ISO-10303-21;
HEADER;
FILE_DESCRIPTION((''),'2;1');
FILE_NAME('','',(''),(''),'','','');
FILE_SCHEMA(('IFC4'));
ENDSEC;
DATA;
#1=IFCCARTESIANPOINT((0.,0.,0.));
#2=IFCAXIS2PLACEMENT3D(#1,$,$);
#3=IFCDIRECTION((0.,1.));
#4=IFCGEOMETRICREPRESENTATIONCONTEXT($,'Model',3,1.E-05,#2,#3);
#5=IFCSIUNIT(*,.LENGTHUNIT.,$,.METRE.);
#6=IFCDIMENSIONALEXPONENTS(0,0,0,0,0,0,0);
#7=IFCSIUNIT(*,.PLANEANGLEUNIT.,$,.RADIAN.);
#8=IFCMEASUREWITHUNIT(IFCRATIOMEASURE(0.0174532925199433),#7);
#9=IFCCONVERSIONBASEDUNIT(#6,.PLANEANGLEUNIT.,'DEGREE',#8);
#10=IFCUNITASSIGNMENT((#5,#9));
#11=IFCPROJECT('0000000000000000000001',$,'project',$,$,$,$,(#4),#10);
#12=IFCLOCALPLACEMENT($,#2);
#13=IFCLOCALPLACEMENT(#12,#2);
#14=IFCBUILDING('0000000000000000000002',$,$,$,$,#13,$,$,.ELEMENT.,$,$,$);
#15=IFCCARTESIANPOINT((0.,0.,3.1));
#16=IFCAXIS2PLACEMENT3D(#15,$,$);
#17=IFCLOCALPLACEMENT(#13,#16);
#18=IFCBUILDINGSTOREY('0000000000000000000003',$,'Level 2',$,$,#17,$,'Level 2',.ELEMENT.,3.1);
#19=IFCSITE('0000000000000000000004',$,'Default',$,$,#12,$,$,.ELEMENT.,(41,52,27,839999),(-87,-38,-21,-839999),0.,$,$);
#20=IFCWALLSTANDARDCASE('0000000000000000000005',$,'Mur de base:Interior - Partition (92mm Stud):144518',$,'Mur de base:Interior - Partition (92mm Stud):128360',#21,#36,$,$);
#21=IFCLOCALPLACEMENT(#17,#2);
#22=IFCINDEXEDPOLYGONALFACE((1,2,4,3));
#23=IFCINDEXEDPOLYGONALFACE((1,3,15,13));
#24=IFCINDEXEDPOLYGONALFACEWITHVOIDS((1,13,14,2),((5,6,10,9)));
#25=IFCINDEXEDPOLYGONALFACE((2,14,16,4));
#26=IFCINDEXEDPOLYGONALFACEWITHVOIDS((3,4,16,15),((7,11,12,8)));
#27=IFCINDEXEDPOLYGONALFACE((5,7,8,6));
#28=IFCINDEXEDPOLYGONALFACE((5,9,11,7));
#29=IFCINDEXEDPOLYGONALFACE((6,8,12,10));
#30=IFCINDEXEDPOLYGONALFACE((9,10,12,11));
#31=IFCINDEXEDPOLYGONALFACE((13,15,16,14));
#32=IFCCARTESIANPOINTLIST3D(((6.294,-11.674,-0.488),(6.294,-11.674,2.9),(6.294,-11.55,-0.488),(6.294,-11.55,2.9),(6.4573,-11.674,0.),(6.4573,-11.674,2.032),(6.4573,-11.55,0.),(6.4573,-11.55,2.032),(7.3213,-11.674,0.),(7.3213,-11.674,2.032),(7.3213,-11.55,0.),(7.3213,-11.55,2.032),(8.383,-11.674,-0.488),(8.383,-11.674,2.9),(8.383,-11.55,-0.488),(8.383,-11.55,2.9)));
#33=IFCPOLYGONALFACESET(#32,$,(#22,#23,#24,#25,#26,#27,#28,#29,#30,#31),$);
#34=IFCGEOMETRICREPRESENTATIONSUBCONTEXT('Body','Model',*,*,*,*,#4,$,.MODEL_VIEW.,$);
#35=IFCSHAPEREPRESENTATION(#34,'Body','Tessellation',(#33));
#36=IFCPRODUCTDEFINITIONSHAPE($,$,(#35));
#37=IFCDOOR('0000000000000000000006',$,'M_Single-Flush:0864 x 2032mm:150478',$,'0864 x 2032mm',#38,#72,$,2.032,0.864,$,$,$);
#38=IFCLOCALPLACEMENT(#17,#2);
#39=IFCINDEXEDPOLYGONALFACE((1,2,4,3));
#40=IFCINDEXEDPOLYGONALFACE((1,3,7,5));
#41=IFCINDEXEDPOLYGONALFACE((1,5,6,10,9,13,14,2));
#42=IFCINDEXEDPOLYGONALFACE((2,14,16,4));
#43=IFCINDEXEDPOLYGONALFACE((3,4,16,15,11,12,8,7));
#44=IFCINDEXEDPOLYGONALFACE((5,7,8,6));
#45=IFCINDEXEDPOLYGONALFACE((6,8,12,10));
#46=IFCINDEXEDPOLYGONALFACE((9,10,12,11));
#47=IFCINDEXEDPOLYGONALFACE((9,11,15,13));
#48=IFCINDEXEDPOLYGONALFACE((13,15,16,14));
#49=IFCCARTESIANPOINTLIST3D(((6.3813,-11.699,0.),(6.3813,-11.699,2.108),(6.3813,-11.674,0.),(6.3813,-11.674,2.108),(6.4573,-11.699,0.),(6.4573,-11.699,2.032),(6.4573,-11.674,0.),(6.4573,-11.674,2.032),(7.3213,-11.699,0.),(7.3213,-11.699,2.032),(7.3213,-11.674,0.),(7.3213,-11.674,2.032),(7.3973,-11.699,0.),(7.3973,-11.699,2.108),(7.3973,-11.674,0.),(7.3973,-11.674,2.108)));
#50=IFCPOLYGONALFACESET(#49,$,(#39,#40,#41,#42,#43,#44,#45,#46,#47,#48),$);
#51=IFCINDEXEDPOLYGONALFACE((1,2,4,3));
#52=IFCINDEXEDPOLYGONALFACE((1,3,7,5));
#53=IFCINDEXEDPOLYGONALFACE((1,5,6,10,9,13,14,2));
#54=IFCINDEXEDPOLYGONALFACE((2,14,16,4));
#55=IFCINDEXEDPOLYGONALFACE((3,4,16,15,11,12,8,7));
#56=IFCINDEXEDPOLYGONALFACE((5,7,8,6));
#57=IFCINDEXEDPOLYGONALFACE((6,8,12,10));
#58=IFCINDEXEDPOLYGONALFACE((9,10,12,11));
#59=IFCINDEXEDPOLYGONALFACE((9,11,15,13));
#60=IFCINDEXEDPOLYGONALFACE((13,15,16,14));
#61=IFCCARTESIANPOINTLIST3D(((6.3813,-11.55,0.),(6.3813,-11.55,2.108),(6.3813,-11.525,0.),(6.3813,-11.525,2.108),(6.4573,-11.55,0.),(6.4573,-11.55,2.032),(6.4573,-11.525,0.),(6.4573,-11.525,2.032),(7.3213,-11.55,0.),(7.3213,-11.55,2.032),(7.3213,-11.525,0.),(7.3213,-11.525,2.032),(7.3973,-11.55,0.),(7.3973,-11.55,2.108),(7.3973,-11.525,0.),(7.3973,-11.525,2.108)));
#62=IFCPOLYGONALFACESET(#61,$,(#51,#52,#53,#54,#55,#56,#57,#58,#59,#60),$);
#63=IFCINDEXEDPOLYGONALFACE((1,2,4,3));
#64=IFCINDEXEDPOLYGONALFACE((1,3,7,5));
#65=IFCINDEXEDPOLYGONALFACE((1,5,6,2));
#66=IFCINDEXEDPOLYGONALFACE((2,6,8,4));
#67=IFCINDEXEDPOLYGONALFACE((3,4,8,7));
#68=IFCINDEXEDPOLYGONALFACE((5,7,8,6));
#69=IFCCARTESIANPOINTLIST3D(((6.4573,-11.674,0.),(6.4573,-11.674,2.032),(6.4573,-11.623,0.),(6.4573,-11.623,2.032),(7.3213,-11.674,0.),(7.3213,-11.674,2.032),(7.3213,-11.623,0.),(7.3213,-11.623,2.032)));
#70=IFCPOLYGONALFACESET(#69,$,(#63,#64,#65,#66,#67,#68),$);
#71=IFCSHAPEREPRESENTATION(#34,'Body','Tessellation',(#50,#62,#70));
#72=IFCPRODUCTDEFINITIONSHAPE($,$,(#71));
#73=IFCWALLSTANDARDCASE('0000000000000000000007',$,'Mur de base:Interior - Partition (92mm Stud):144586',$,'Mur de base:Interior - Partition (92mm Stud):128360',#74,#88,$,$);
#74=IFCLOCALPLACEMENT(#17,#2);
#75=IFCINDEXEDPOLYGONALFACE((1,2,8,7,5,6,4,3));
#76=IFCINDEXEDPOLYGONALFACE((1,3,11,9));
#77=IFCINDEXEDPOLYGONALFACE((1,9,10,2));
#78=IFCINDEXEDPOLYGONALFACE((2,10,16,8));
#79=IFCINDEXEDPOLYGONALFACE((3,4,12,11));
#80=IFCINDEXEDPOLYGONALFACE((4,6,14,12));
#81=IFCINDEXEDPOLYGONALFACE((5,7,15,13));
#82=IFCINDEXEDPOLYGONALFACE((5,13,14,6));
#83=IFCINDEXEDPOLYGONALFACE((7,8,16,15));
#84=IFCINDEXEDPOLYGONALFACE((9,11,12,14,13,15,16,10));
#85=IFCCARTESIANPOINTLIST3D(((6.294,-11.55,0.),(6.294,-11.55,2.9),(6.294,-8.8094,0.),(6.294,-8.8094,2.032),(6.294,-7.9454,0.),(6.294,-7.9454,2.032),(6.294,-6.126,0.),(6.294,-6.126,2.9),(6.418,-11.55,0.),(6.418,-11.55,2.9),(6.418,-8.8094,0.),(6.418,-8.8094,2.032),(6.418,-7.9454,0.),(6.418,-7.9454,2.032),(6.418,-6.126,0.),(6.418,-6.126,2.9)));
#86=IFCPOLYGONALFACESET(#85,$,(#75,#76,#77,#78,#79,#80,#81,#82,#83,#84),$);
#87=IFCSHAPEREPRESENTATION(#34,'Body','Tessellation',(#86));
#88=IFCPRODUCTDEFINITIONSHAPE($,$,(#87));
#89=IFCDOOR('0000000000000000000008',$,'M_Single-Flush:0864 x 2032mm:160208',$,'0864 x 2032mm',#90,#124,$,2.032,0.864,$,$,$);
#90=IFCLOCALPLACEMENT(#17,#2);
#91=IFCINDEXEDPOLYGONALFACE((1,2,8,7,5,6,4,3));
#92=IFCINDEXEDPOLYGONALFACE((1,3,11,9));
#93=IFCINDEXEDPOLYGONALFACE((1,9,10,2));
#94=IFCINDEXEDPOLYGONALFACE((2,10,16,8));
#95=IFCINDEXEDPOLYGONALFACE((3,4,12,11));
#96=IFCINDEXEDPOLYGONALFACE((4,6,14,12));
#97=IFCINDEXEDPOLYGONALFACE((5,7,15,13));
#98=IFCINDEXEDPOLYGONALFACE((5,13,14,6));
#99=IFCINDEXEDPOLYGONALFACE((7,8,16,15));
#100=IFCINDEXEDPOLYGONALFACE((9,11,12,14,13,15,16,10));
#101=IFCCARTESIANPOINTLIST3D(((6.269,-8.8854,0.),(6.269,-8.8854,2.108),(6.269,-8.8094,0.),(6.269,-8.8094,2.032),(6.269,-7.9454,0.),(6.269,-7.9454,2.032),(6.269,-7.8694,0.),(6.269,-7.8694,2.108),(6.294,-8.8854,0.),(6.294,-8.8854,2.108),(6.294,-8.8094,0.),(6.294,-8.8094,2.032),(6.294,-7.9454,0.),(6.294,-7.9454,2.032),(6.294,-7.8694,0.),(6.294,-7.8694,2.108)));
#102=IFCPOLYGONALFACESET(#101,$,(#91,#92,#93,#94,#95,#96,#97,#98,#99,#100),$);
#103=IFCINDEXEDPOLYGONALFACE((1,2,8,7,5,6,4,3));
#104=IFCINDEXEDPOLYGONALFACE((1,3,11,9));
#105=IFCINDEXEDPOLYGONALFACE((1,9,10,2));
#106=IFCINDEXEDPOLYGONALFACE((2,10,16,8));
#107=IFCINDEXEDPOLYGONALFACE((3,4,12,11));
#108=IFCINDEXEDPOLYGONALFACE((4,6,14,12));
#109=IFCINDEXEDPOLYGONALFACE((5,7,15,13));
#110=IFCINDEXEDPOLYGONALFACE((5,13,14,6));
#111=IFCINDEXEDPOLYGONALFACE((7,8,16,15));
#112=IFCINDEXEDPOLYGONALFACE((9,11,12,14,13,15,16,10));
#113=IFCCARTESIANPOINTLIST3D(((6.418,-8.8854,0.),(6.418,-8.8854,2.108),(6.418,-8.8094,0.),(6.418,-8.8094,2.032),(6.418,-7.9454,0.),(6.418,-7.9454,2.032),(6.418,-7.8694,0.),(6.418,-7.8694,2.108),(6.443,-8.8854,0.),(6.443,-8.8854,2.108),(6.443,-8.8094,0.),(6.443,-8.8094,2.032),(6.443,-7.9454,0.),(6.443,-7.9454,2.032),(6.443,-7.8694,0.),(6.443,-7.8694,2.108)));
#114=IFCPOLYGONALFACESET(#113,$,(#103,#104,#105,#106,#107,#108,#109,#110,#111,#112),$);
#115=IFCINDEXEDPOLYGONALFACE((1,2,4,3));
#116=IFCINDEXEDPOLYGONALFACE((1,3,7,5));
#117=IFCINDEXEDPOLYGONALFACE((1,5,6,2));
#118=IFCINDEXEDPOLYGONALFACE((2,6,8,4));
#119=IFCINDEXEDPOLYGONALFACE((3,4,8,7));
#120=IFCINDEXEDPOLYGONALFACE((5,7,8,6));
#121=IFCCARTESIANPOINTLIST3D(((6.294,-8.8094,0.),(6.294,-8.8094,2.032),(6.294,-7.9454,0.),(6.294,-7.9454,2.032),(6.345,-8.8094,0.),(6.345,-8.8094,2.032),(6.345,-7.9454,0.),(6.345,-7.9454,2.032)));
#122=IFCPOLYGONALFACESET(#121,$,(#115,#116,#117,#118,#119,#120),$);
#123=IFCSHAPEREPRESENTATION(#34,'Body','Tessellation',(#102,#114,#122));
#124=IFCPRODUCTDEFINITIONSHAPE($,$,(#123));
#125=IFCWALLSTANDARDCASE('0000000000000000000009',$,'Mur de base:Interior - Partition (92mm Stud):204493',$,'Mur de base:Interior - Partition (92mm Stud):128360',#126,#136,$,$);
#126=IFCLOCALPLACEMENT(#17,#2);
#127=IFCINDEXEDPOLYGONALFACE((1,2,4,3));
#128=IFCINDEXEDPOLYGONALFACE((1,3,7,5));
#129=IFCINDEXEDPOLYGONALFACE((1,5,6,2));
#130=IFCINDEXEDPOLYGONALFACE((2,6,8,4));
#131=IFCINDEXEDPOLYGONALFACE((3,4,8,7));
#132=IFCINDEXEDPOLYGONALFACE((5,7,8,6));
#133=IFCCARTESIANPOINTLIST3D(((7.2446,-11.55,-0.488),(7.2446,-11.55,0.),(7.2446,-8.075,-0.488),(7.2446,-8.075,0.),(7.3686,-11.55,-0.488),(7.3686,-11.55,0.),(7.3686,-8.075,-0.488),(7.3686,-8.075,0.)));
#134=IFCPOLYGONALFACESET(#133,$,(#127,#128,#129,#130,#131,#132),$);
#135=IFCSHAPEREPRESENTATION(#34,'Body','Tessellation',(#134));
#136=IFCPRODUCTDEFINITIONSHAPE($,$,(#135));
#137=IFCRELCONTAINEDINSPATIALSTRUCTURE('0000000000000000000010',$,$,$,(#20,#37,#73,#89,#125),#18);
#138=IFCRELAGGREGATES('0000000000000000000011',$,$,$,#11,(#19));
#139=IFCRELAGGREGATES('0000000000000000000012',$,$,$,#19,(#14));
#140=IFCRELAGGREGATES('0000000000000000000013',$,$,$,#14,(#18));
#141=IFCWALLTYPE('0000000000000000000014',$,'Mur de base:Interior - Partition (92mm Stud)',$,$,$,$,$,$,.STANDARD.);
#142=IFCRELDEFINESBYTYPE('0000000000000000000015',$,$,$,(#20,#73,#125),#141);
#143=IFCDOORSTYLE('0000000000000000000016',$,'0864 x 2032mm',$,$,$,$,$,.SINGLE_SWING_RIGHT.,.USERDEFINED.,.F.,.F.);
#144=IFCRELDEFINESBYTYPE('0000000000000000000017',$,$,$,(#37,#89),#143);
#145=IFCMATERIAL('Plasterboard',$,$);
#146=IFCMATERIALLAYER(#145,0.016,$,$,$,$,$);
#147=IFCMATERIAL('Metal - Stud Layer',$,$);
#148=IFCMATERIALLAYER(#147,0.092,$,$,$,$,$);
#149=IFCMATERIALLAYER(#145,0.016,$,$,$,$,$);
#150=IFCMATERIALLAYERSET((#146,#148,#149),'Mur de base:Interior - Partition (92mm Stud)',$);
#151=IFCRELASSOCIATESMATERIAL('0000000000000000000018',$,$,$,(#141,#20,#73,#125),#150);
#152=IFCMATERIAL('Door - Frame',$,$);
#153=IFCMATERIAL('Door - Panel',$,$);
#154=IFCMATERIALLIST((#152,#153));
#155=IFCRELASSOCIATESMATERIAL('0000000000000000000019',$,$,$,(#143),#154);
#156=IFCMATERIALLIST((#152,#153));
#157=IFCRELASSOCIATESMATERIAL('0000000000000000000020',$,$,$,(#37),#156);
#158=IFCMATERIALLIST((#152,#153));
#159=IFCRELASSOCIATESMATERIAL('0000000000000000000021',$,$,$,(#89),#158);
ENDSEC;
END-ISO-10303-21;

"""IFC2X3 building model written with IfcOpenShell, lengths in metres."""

from ifc_helpers import new_model, entity, si_unit, converted_unit, direction, frame, frame_2d, origin, origin_2d_with_axis, place, context, subcontext, project, spatial, polyline, rectangle, outline, extrude, source, transform, mapped, material, material_list, layer, layer_set, layer_usage, type_object, type_shapes, element, fill, save


model = new_model("IFC2X3")

# Units and contexts
model_context = context("Model", 3, precision=1e-05, world=origin(), true_north=direction((0.0, 1.0)))
body_context = subcontext(model_context, "Body", "Model", "MODEL_VIEW")
ifc_project = project(units=[si_unit("LENGTHUNIT", "METRE"), converted_unit("PLANEANGLEUNIT", "DEGREE", entity("IfcRatioMeasure", 0.0174532925199433), si_unit("PLANEANGLEUNIT", "RADIAN"), dimensions=[0, 0, 0, 0, 0, 0, 0])], contexts=[model_context])

# Site, building, storey
site_placement = place(None, origin())
site = spatial("IfcSite", under=ifc_project, at=site_placement, Name="Default", CompositionType="ELEMENT", RefLatitude=(41, 52, 27, 839999), RefLongitude=(-87, -38, -21, -839999), RefElevation=0.0)
building_placement = place(site_placement, origin())
building = spatial("IfcBuilding", under=site, at=building_placement, CompositionType="ELEMENT")
storey_placement = place(building_placement, frame((0.0, 0.0, 3.1)))
storey = spatial("IfcBuildingStorey", under=building, at=storey_placement, Name="Level 2", LongName="Level 2", CompositionType="ELEMENT", Elevation=3.1)

# Shared definitions
ifc_material_1 = material(Name="Metal - Stud Layer")
ifc_material_2 = material(Name="Plasterboard")

# Wall, opening, door
ifc_layer_1 = layer(ifc_material_2, 0.016)
ifc_layer_2 = layer(ifc_material_1, 0.092)
ifc_layer_3 = layer(ifc_material_2, 0.016)
ifc_layer_set_1 = layer_set([ifc_layer_1, ifc_layer_2, ifc_layer_3], Name="Mur de base:Interior - Partition (92mm Stud)")
ifc_layer_usage_1 = layer_usage(ifc_layer_set_1, "AXIS2", "NEGATIVE", 0.062)
wall_type_1 = type_object("IfcWallType", Name="Mur de base:Interior - Partition (92mm Stud)", PredefinedType="STANDARD", material=ifc_layer_set_1)
wall_1_placement = place(storey_placement, frame((8.383, -11.612, -0.488), z_axis=(0.0, 0.0, 1.0), x_axis=(-1.0, 0.0, 0.0)))
wall_1 = element("IfcWallStandardCase", 1, at=wall_1_placement, inside=storey, type_object=wall_type_1, material=ifc_layer_usage_1, Name="Mur de base:Interior - Partition (92mm Stud):144518", ObjectType="Mur de base:Interior - Partition (92mm Stud):128360", context=body_context, shape_type="SweptSolid", body=[
    extrude(rectangle(XDim=2.089, YDim=0.124, at=frame_2d((1.0445, 0.0), x_axis=(-1.0, 0.0))), origin(), (0.0, 0.0, 1.0), 3.388),
])
opening_1_placement = place(wall_1_placement, frame((1.0617, -0.062, 0.488)))
opening_1 = element("IfcOpeningElement", 2, at=opening_1_placement, cuts=wall_1, ObjectType="Opening", context=body_context, shape_type="SweptSolid", body=[
    extrude(rectangle(XDim=0.864, YDim=2.032, at=frame_2d((1.016, 0.432), x_axis=(0.0, 1.0))), frame((0.0, 0.0, 0.0), z_axis=(0.0, 1.0, 0.0), x_axis=(0.0, 0.0, 1.0)), (0.0, 0.0, 1.0), 0.124),
])
ifc_material_3 = material(Name="Door - Frame")
ifc_material_4 = material(Name="Door - Panel")
ifc_material_list_1 = material_list([ifc_material_3, ifc_material_4])
ifc_material_list_2 = material_list([ifc_material_3, ifc_material_4])
door_style = type_object("IfcDoorStyle", Name="0864 x 2032mm", ConstructionType="USERDEFINED", OperationType="SINGLE_SWING_RIGHT", ParameterTakesPrecedence=False, Sizeable=False, material=ifc_material_list_2)
shared_shape_1 = source(origin(), body_context, "Body", "SweptSolid", [
    extrude(outline(polyline([(-0.508, -1.073), (0.508, -1.073), (0.508, 1.035), (0.432, 1.035), (0.432, -0.997), (-0.432, -0.997), (-0.432, 1.035), (-0.508, 1.035), (-0.508, -1.073)])), frame((0.432, 0.124, 1.035), z_axis=(0.0, 1.0, 0.0), x_axis=(1.0, 0.0, 0.0)), (0.0, 0.0, 1.0), 0.025),
    extrude(outline(polyline([(-1.073, -0.508), (1.035, -0.508), (1.035, -0.432), (-0.997, -0.432), (-0.997, 0.432), (1.035, 0.432), (1.035, 0.508), (-1.073, 0.508), (-1.073, -0.508)])), frame((0.432, -0.025, 1.035), z_axis=(0.0, 1.0, 0.0), x_axis=(0.0, 0.0, -1.0)), (0.0, 0.0, 1.0), 0.025),
    extrude(rectangle(XDim=0.051, YDim=0.864, at=origin_2d_with_axis()), frame((0.432, 0.0985, 0.0), z_axis=(0.0, 0.0, 1.0), x_axis=(0.0, 1.0, 0.0)), (0.0, 0.0, 1.0), 2.032),
])
type_shapes(door_style, [shared_shape_1])
door_1_placement = place(opening_1_placement, origin())
door_1 = element("IfcDoor", 3, at=door_1_placement, inside=storey, type_object=door_style, material=ifc_material_list_1, Name="M_Single-Flush:0864 x 2032mm:150478", ObjectType="0864 x 2032mm", OverallHeight=2.032, OverallWidth=0.864, context=body_context, shape_type="MappedRepresentation", body=[
    mapped(shared_shape_1, transform((0.0, 0.0, 0.0), scale=1.0)),
])
fill(opening_1, door_1)

# Wall, openings, door
ifc_layer_usage_2 = layer_usage(ifc_layer_set_1, "AXIS2", "NEGATIVE", 0.062)
wall_2_placement = place(storey_placement, frame((6.356, -11.55, 0.0), z_axis=(0.0, 0.0, 1.0), x_axis=(0.0, 1.0, 0.0)))
wall_2 = element("IfcWallStandardCase", 4, at=wall_2_placement, inside=storey, type_object=wall_type_1, material=ifc_layer_usage_2, Name="Mur de base:Interior - Partition (92mm Stud):144586", ObjectType="Mur de base:Interior - Partition (92mm Stud):128360", context=body_context, shape_type="SweptSolid", body=[
    extrude(rectangle(XDim=5.424, YDim=0.124, at=frame_2d((2.712, 0.0), x_axis=(-1.0, 0.0))), origin(), (0.0, 0.0, 1.0), 2.9),
])
opening_2_placement = place(wall_2_placement, origin())
element("IfcOpeningElement", 5, at=opening_2_placement, cuts=wall_2, ObjectType="Opening", context=body_context, shape_type="SweptSolid", body=[
    extrude(rectangle(XDim=2.032, YDim=0.124, at=frame_2d((0.0, 0.0), x_axis=(0.0, 1.0))), frame((3.7666, 0.0626, 1.016), z_axis=(0.0, 1.0, 0.0), x_axis=(1.0, 0.0, 0.0)), (0.0, 0.0, 1.0), 0.762),
])
opening_3_placement = place(wall_2_placement, frame((2.7406, -0.062, 0.0)))
opening_3 = element("IfcOpeningElement", 6, at=opening_3_placement, cuts=wall_2, ObjectType="Opening", context=body_context, shape_type="SweptSolid", body=[
    extrude(rectangle(XDim=0.864, YDim=2.032, at=frame_2d((1.016, 0.432), x_axis=(0.0, 1.0))), frame((0.0, 0.0, 0.0), z_axis=(0.0, 1.0, 0.0), x_axis=(0.0, 0.0, 1.0)), (0.0, 0.0, 1.0), 0.124),
])
ifc_material_list_3 = material_list([ifc_material_3, ifc_material_4])
door_2_placement = place(opening_3_placement, origin())
door_2 = element("IfcDoor", 7, at=door_2_placement, inside=storey, type_object=door_style, material=ifc_material_list_3, Name="M_Single-Flush:0864 x 2032mm:160208", ObjectType="0864 x 2032mm", OverallHeight=2.032, OverallWidth=0.864, context=body_context, shape_type="MappedRepresentation", body=[
    mapped(shared_shape_1, transform((0.0, 0.0, 0.0), scale=1.0)),
])
fill(opening_3, door_2)

# Wall
ifc_layer_usage_3 = layer_usage(ifc_layer_set_1, "AXIS2", "NEGATIVE", 0.062)
wall_3_placement = place(storey_placement, frame((7.3066, -11.55, -0.488), z_axis=(0.0, 0.0, 1.0), x_axis=(0.0, 1.0, 0.0)))
element("IfcWallStandardCase", 8, at=wall_3_placement, inside=storey, type_object=wall_type_1, material=ifc_layer_usage_3, Name="Mur de base:Interior - Partition (92mm Stud):204493", ObjectType="Mur de base:Interior - Partition (92mm Stud):128360", context=body_context, shape_type="SweptSolid", body=[
    extrude(rectangle(XDim=3.475, YDim=0.124, at=frame_2d((1.7375, 0.0), x_axis=(-1.0, 0.0))), origin(), (0.0, 0.0, 1.0), 0.488),
])

save(model, "model.ifc")
